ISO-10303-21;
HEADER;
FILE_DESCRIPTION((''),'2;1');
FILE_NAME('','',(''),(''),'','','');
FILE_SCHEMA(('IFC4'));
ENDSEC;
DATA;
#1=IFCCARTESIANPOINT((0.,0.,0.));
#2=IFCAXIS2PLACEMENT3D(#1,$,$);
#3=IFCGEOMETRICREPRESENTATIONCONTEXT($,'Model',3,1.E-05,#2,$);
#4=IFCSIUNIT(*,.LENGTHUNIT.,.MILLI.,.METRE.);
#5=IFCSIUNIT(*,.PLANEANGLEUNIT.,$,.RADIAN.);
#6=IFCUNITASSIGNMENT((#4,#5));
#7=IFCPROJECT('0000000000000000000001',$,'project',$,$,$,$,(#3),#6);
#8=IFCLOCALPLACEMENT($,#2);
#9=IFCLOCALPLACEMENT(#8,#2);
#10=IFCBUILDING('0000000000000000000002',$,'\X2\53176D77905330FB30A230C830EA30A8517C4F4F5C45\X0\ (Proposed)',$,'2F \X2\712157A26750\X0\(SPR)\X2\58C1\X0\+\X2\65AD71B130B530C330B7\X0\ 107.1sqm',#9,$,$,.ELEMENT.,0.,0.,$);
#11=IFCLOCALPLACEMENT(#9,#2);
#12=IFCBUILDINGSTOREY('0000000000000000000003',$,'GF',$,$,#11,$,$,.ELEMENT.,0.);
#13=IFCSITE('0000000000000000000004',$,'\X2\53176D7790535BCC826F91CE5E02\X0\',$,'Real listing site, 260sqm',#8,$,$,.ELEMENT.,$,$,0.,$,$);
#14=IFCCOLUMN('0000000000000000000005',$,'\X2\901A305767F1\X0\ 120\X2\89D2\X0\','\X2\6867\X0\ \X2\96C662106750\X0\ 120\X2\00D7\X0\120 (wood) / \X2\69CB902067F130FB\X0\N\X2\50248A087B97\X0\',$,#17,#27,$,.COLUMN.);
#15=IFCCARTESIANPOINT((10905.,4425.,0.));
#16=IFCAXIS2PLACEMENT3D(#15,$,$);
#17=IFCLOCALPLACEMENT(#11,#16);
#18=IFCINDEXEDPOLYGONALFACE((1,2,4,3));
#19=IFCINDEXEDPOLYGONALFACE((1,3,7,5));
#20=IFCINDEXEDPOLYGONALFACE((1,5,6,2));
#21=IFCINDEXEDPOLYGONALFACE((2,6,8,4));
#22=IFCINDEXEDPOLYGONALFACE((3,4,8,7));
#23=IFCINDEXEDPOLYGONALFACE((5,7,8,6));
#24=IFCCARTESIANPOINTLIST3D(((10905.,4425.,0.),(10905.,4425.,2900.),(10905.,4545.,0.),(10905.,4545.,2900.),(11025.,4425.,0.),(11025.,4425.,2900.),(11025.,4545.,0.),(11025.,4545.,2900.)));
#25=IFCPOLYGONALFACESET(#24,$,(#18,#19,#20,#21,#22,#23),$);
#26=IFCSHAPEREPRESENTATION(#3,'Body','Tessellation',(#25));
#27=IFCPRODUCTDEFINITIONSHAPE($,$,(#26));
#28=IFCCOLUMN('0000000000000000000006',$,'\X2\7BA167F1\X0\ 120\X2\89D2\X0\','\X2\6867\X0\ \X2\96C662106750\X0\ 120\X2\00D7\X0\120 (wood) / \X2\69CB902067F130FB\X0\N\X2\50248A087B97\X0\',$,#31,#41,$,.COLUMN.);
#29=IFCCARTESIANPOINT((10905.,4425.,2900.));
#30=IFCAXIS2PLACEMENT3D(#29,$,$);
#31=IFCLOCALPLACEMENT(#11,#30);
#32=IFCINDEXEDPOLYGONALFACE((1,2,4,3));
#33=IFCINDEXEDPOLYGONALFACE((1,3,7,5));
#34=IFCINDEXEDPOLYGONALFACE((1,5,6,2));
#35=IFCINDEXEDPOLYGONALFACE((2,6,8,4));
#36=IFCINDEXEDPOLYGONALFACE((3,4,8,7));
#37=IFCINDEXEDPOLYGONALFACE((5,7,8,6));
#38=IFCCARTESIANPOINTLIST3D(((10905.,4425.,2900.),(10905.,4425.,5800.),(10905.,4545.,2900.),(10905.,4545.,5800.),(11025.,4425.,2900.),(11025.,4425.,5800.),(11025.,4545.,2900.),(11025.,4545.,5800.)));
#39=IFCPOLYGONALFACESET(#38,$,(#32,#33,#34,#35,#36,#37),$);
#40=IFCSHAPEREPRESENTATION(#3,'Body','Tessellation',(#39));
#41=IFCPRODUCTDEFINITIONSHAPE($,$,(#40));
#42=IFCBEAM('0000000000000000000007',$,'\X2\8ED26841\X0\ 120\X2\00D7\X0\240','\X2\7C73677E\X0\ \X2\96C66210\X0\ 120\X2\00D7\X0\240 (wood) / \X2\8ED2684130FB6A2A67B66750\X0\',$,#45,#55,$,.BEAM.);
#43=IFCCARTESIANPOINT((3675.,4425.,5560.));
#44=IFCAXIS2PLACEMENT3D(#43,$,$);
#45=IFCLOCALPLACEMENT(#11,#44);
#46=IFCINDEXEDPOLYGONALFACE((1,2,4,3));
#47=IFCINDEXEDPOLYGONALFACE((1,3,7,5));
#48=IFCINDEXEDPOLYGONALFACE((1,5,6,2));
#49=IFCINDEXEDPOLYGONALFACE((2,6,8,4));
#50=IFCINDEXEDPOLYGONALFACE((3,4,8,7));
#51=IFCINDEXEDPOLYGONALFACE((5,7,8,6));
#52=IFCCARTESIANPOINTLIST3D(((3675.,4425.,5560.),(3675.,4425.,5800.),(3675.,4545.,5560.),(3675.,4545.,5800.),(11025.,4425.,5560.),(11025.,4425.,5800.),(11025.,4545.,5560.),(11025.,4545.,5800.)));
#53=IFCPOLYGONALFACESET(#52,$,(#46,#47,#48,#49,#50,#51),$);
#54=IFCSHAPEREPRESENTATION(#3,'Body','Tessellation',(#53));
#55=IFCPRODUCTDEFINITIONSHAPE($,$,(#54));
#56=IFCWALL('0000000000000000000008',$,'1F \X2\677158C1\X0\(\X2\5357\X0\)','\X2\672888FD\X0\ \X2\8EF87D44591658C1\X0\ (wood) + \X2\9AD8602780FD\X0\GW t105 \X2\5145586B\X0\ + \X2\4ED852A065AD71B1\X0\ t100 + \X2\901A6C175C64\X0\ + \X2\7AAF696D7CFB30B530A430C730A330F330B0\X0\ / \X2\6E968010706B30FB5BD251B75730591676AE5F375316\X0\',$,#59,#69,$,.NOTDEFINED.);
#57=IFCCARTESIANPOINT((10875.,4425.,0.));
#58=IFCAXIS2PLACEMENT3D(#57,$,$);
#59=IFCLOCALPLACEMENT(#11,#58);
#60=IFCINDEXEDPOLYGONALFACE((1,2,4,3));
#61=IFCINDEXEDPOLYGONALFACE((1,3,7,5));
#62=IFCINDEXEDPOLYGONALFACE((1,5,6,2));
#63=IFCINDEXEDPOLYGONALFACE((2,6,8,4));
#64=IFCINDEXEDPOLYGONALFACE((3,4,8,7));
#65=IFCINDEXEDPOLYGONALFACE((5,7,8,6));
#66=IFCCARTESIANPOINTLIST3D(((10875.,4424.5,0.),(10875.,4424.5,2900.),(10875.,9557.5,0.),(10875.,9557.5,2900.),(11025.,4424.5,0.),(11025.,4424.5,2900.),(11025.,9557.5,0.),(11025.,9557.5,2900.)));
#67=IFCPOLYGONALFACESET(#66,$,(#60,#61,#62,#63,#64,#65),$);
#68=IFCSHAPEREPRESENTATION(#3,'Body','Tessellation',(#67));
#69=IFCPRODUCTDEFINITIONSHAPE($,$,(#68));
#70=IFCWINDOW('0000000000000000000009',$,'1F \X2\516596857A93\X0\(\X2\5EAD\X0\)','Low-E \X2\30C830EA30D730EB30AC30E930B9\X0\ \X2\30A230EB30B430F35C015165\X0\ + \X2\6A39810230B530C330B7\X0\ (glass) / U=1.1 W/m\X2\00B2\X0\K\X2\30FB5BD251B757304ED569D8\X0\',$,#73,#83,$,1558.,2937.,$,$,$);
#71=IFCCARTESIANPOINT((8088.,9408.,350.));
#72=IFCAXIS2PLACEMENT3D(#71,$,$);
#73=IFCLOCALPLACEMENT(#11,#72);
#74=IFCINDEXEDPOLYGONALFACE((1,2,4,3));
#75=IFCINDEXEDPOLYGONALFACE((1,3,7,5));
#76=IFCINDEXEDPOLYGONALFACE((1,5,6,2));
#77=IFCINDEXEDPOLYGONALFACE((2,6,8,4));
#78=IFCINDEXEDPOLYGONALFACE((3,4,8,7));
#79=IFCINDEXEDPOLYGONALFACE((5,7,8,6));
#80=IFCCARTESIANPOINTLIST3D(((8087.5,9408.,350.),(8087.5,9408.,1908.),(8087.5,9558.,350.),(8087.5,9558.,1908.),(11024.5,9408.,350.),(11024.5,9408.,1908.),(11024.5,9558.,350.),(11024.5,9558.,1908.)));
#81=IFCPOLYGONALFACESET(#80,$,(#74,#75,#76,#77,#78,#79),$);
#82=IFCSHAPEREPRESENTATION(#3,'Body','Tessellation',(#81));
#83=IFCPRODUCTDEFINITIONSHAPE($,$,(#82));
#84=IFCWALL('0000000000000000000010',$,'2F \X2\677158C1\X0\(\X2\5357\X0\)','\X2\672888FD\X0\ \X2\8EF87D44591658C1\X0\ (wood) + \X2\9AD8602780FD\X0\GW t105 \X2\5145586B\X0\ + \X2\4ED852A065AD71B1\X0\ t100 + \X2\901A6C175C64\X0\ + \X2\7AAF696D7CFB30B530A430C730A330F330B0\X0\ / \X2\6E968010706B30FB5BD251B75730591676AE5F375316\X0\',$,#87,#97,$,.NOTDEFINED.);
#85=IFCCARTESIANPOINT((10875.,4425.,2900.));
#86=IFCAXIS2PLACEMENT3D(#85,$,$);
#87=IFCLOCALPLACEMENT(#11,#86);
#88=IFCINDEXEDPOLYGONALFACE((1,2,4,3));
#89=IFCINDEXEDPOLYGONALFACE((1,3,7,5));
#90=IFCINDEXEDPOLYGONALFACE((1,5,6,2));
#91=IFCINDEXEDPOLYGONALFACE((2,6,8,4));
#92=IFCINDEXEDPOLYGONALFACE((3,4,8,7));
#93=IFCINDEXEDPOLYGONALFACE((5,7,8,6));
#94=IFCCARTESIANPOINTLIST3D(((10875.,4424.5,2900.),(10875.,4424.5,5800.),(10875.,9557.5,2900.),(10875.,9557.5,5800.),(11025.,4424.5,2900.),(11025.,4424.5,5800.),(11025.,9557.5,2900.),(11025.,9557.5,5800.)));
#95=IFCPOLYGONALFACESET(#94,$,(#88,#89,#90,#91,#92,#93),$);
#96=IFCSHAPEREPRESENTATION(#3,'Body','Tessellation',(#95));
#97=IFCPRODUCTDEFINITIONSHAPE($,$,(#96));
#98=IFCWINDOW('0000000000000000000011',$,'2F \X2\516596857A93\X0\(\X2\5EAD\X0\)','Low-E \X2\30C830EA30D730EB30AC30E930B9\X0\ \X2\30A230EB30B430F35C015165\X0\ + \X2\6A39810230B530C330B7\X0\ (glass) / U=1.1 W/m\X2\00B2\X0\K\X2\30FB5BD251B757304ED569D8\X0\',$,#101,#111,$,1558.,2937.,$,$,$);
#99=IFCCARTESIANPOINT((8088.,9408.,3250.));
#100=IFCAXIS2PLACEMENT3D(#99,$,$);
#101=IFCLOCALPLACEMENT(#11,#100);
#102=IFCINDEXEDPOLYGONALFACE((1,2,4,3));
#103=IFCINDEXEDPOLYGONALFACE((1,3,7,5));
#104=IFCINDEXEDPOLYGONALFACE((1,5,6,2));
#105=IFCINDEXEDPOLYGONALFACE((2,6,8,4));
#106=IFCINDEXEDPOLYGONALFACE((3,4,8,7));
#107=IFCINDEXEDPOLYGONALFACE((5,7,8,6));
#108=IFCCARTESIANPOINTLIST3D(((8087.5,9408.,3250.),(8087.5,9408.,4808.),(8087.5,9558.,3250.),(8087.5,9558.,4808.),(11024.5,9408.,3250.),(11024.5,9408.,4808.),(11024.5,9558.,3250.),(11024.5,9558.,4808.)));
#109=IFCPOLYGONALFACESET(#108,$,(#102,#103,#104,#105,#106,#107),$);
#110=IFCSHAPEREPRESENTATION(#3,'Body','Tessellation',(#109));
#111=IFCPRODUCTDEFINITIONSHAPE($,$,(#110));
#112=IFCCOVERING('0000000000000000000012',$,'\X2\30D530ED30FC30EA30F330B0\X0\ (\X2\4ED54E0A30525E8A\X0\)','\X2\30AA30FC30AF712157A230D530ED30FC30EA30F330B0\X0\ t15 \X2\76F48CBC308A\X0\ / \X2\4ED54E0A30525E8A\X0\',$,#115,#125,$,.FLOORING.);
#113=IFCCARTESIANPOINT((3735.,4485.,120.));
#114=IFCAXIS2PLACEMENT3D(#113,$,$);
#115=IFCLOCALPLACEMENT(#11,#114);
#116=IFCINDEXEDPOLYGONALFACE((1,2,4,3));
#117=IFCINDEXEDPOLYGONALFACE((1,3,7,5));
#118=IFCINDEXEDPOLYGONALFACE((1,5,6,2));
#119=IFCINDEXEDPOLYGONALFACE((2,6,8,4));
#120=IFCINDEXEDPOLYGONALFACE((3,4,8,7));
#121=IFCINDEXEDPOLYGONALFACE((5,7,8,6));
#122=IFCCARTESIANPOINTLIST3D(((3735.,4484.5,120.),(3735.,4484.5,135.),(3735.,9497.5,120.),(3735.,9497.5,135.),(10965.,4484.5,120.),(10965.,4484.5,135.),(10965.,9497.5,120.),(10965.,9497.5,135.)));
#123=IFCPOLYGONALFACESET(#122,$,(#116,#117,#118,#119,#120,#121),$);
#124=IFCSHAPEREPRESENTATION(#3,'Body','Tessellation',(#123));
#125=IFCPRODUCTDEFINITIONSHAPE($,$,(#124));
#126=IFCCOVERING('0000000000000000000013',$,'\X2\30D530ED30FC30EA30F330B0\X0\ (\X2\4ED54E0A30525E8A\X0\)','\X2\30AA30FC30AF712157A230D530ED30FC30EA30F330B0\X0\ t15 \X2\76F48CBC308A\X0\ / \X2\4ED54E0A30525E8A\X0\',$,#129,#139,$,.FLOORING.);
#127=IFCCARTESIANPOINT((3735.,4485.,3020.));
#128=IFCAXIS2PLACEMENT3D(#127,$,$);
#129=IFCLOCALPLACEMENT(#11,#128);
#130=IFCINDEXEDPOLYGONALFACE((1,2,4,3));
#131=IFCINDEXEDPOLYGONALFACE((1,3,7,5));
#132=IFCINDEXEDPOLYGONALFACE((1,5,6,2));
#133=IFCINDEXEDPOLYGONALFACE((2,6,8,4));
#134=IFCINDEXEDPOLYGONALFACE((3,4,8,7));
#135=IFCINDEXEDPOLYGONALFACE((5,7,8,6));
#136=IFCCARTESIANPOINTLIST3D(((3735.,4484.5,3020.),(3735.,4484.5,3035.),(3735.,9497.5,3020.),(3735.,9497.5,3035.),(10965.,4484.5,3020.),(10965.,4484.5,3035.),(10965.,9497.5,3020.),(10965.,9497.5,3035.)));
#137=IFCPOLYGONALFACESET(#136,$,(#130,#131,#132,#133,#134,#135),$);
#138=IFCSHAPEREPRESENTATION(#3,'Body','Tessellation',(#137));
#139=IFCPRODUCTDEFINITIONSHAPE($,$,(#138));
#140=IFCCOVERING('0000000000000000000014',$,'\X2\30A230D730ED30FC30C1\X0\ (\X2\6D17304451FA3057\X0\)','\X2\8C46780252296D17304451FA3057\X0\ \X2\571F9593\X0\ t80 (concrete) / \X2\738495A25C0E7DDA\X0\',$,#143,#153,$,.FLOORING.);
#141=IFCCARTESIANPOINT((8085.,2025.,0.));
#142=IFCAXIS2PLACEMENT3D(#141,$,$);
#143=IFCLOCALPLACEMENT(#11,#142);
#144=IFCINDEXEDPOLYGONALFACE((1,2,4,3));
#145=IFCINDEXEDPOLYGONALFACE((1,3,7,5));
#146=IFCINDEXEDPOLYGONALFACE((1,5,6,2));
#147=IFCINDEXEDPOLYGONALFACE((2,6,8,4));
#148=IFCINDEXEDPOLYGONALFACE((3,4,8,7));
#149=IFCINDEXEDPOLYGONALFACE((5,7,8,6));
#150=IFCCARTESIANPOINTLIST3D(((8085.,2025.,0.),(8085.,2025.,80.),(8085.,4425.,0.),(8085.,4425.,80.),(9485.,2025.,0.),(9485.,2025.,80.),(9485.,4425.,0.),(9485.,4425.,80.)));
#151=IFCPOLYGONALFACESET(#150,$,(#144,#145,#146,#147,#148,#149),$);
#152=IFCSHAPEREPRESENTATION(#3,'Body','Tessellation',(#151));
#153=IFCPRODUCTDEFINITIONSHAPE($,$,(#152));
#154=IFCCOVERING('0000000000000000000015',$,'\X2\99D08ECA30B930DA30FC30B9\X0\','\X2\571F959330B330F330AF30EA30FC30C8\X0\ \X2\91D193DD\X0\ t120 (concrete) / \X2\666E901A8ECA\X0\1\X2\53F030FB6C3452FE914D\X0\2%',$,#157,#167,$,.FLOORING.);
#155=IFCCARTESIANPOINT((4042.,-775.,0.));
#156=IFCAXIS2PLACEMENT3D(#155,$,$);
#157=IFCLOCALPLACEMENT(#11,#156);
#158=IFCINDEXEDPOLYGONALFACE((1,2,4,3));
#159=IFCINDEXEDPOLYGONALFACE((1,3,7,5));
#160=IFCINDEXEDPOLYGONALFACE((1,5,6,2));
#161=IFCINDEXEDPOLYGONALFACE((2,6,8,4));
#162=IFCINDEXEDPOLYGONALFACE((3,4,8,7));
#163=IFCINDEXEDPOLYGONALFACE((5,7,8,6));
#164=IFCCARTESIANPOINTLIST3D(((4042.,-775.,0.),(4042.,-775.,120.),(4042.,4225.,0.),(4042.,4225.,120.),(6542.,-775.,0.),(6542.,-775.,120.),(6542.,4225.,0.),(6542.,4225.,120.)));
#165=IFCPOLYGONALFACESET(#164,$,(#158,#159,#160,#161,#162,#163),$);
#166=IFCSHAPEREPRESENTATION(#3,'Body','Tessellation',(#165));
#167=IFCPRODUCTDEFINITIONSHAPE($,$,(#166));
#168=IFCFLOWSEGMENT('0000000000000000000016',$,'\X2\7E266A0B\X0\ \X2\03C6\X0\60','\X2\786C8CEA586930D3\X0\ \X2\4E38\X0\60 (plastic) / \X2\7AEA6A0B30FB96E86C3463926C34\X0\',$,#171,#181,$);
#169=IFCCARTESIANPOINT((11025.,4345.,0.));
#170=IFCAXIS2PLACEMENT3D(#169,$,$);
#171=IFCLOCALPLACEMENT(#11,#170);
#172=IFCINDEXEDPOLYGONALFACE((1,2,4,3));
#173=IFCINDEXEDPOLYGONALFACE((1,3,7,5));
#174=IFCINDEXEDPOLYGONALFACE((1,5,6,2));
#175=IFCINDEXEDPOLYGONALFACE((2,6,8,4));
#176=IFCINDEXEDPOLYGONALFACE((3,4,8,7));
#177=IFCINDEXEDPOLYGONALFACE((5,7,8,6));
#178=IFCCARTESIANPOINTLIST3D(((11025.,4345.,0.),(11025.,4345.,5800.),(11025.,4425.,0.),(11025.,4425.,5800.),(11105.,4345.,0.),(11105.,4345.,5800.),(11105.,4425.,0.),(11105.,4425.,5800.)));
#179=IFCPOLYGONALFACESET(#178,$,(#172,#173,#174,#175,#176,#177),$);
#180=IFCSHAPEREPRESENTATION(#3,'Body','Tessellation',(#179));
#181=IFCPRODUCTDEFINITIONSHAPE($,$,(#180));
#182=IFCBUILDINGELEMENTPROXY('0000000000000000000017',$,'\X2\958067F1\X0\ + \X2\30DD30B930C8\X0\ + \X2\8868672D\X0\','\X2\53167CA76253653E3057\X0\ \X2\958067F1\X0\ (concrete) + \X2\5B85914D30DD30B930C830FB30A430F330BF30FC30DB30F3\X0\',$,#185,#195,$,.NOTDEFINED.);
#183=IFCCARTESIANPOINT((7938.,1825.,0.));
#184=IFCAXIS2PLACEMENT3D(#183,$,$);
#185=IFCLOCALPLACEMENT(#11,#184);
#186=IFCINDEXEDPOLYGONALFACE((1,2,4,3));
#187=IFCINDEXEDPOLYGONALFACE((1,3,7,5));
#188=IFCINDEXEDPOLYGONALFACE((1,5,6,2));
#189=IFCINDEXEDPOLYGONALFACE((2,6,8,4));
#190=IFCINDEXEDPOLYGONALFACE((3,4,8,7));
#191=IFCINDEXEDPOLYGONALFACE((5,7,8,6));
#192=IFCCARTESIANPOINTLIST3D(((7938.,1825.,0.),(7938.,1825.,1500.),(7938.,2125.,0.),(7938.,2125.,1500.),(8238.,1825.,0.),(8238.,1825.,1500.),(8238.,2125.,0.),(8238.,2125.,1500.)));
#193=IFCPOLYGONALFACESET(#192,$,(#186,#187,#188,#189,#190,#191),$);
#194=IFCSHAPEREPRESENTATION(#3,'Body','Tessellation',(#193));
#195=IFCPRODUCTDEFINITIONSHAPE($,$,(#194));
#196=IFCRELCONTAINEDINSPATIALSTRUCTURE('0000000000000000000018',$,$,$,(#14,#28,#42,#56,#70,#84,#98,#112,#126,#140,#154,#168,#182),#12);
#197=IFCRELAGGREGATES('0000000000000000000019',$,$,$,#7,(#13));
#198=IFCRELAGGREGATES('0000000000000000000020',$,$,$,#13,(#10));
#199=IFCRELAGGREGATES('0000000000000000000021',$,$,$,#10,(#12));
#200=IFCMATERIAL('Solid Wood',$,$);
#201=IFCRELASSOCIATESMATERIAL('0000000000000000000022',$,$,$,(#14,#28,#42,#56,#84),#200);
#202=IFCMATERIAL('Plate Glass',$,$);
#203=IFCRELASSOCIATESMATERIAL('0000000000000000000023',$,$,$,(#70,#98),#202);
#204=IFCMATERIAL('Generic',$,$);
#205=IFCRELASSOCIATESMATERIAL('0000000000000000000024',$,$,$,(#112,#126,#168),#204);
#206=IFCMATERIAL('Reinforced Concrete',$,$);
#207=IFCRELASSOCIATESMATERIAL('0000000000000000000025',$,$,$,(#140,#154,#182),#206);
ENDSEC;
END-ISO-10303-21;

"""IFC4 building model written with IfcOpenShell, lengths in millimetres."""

from ifc_helpers import new_model, si_unit, frame, frame_2d, origin, place, context, project, spatial, rectangle, extrude, material, element, fill, save


model = new_model("IFC4")

# Units and contexts
model_context = context("Model", 3, precision=1e-05, world=origin())
ifc_project = project(units=[si_unit("LENGTHUNIT", "METRE", prefix="MILLI"), si_unit("PLANEANGLEUNIT", "RADIAN")], contexts=[model_context])

# Site, building, storey
site_placement = place(None, origin())
site = spatial("IfcSite", under=ifc_project, at=site_placement, Name="北海道富良野市", ObjectType="Real listing site, 260sqm", CompositionType="ELEMENT", RefElevation=0.0)
building_placement = place(site_placement, origin())
building = spatial("IfcBuilding", under=site, at=building_placement, Name="北海道・アトリエ兼住居 (Proposed)", ObjectType="2F 無垢材(SPR)壁+断熱サッシ 107.1sqm", CompositionType="ELEMENT", ElevationOfRefHeight=0.0, ElevationOfTerrain=0.0)
storey_placement = place(building_placement, origin())
storey = spatial("IfcBuildingStorey", under=building, at=storey_placement, Name="GF", CompositionType="ELEMENT", Elevation=0.0)

# Columns
ifc_material_1 = material(Name="Solid Wood")
column_1_placement = place(storey_placement, frame((10905.0, 4425.0, 0.0)))
element("IfcColumn", 1, at=column_1_placement, inside=storey, material=ifc_material_1, Name="通し柱 120角", Description="桧 集成材 120×120 (wood) / 構造柱・N値計算", PredefinedType="COLUMN", context=model_context, shape_type="SweptSolid", body=[
    extrude(rectangle(XDim=120.0, YDim=120.0, at=frame_2d((60.0, 60.0))), frame((10905.0, 4425.0, 0.0)), (0.0, 0.0, 1.0), 2900.0),
])
column_2_placement = place(storey_placement, frame((10905.0, 4425.0, 2900.0)))
element("IfcColumn", 2, at=column_2_placement, inside=storey, material=ifc_material_1, Name="管柱 120角", Description="桧 集成材 120×120 (wood) / 構造柱・N値計算", PredefinedType="COLUMN", context=model_context, shape_type="SweptSolid", body=[
    extrude(rectangle(XDim=120.0, YDim=120.0, at=frame_2d((60.0, 60.0))), frame((10905.0, 4425.0, 2900.0)), (0.0, 0.0, 1.0), 2900.0),
])

# Beam
beam_1_placement = place(storey_placement, frame((3675.0, 4425.0, 5560.0)))
element("IfcBeam", 3, at=beam_1_placement, inside=storey, material=ifc_material_1, Name="軒桁 120×240", Description="米松 集成 120×240 (wood) / 軒桁・横架材", PredefinedType="BEAM", context=model_context, shape_type="SweptSolid", body=[
    extrude(rectangle(XDim=7350.0, YDim=120.0, at=frame_2d((3675.0, 60.0))), frame((3675.0, 4425.0, 5560.0)), (0.0, 0.0, 1.0), 240.0),
])

# Wall, opening, window
wall_1_placement = place(storey_placement, frame((10875.0, 4425.0, 0.0)))
wall_1 = element("IfcWall", 4, at=wall_1_placement, inside=storey, material=ifc_material_1, Name="1F 東壁(南)", Description="木製 軸組外壁 (wood) + 高性能GW t105 充填 + 付加断熱 t100 + 通気層 + 窯業系サイディング / 準耐火・寒冷地外皮強化", PredefinedType="NOTDEFINED", context=model_context, shape_type="SweptSolid", body=[
    extrude(rectangle(XDim=150.0, YDim=5133.0, at=frame_2d((75.0, 2566.0))), frame((10875.0, 4425.0, 0.0)), (0.0, 0.0, 1.0), 2900.0),
])
opening_1_placement = place(storey_placement, frame((8088.0, 9408.0, 350.0)))
opening_1 = element("IfcOpeningElement", 5, at=opening_1_placement, cuts=wall_1, PredefinedType="NOTDEFINED", context=model_context, shape_type="SweptSolid", body=[
    extrude(rectangle(XDim=2937.0, YDim=150.0, at=frame_2d((1468.0, 75.0))), frame((8088.0, 9408.0, 350.0)), (0.0, 0.0, 1.0), 1558.0),
])
ifc_material_2 = material(Name="Plate Glass")
window_1_placement = place(storey_placement, frame((8088.0, 9408.0, 350.0)))
window_1 = element("IfcWindow", 6, at=window_1_placement, inside=storey, material=ifc_material_2, Name="1F 入隅窓(庭)", Description="Low-E トリプルガラス アルゴン封入 + 樹脂サッシ (glass) / U=1.1 W/m²K・寒冷地仕様", OverallHeight=1558.0, OverallWidth=2937.0, context=model_context, shape_type="SweptSolid", body=[
    extrude(rectangle(XDim=2937.0, YDim=150.0, at=frame_2d((1468.0, 75.0))), frame((8088.0, 9408.0, 350.0)), (0.0, 0.0, 1.0), 1558.0),
])
fill(opening_1, window_1)

# Wall, opening, window
wall_2_placement = place(storey_placement, frame((10875.0, 4425.0, 2900.0)))
wall_2 = element("IfcWall", 7, at=wall_2_placement, inside=storey, material=ifc_material_1, Name="2F 東壁(南)", Description="木製 軸組外壁 (wood) + 高性能GW t105 充填 + 付加断熱 t100 + 通気層 + 窯業系サイディング / 準耐火・寒冷地外皮強化", PredefinedType="NOTDEFINED", context=model_context, shape_type="SweptSolid", body=[
    extrude(rectangle(XDim=150.0, YDim=5133.0, at=frame_2d((75.0, 2566.0))), frame((10875.0, 4425.0, 2900.0)), (0.0, 0.0, 1.0), 2900.0),
])
opening_2_placement = place(storey_placement, frame((8088.0, 9408.0, 3250.0)))
opening_2 = element("IfcOpeningElement", 8, at=opening_2_placement, cuts=wall_2, PredefinedType="NOTDEFINED", context=model_context, shape_type="SweptSolid", body=[
    extrude(rectangle(XDim=2937.0, YDim=150.0, at=frame_2d((1468.0, 75.0))), frame((8088.0, 9408.0, 3250.0)), (0.0, 0.0, 1.0), 1558.0),
])
window_2_placement = place(storey_placement, frame((8088.0, 9408.0, 3250.0)))
window_2 = element("IfcWindow", 9, at=window_2_placement, inside=storey, material=ifc_material_2, Name="2F 入隅窓(庭)", Description="Low-E トリプルガラス アルゴン封入 + 樹脂サッシ (glass) / U=1.1 W/m²K・寒冷地仕様", OverallHeight=1558.0, OverallWidth=2937.0, context=model_context, shape_type="SweptSolid", body=[
    extrude(rectangle(XDim=2937.0, YDim=150.0, at=frame_2d((1468.0, 75.0))), frame((8088.0, 9408.0, 3250.0)), (0.0, 0.0, 1.0), 1558.0),
])
fill(opening_2, window_2)

# Coverings
ifc_material_3 = material(Name="Generic")
covering_1_placement = place(storey_placement, frame((3735.0, 4485.0, 120.0)))
element("IfcCovering", 10, at=covering_1_placement, inside=storey, material=ifc_material_3, Name="フローリング (仕上げ床)", Description="オーク無垢フローリング t15 直貼り / 仕上げ床", PredefinedType="FLOORING", context=model_context, shape_type="SweptSolid", body=[
    extrude(rectangle(XDim=7230.0, YDim=5013.0, at=frame_2d((3615.0, 2506.0))), frame((3735.0, 4485.0, 120.0)), (0.0, 0.0, 1.0), 15.0),
])
covering_2_placement = place(storey_placement, frame((3735.0, 4485.0, 3020.0)))
element("IfcCovering", 11, at=covering_2_placement, inside=storey, material=ifc_material_3, Name="フローリング (仕上げ床)", Description="オーク無垢フローリング t15 直貼り / 仕上げ床", PredefinedType="FLOORING", context=model_context, shape_type="SweptSolid", body=[
    extrude(rectangle(XDim=7230.0, YDim=5013.0, at=frame_2d((3615.0, 2506.0))), frame((3735.0, 4485.0, 3020.0)), (0.0, 0.0, 1.0), 15.0),
])
ifc_material_4 = material(Name="Reinforced Concrete")
covering_3_placement = place(storey_placement, frame((8085.0, 2025.0, 0.0)))
element("IfcCovering", 12, at=covering_3_placement, inside=storey, material=ifc_material_4, Name="アプローチ (洗い出し)", Description="豆砂利洗い出し 土間 t80 (concrete) / 玄関導線", PredefinedType="FLOORING", context=model_context, shape_type="SweptSolid", body=[
    extrude(rectangle(XDim=1400.0, YDim=2400.0, at=frame_2d((700.0, 1200.0))), frame((8085.0, 2025.0, 0.0)), (0.0, 0.0, 1.0), 80.0),
])
covering_4_placement = place(storey_placement, frame((4042.0, -775.0, 0.0)))
element("IfcCovering", 13, at=covering_4_placement, inside=storey, material=ifc_material_4, Name="駐車スペース", Description="土間コンクリート 金鏝 t120 (concrete) / 普通車1台・水勾配2%", PredefinedType="FLOORING", context=model_context, shape_type="SweptSolid", body=[
    extrude(rectangle(XDim=2500.0, YDim=5000.0, at=frame_2d((1250.0, 2500.0))), frame((4042.0, -775.0, 0.0)), (0.0, 0.0, 1.0), 120.0),
])

# Flow segment
flow_segment_placement = place(storey_placement, frame((11025.0, 4345.0, 0.0)))
element("IfcFlowSegment", 14, at=flow_segment_placement, inside=storey, material=ifc_material_3, Name="縦樋 φ60", Description="硬質塩ビ 丸60 (plastic) / 竪樋・雨水排水", context=model_context, shape_type="SweptSolid", body=[
    extrude(rectangle(XDim=80.0, YDim=80.0, at=frame_2d((40.0, 40.0))), frame((11025.0, 4345.0, 0.0)), (0.0, 0.0, 1.0), 5800.0),
])

# Building element proxy
proxy_placement = place(storey_placement, frame((7938.0, 1825.0, 0.0)))
element("IfcBuildingElementProxy", 15, at=proxy_placement, inside=storey, material=ifc_material_4, Name="門柱 + ポスト + 表札", Description="化粧打放し 門柱 (concrete) + 宅配ポスト・インターホン", PredefinedType="NOTDEFINED", context=model_context, shape_type="SweptSolid", body=[
    extrude(rectangle(XDim=300.0, YDim=300.0, at=frame_2d((150.0, 150.0))), frame((7938.0, 1825.0, 0.0)), (0.0, 0.0, 1.0), 1500.0),
])

save(model, "model.ifc")
